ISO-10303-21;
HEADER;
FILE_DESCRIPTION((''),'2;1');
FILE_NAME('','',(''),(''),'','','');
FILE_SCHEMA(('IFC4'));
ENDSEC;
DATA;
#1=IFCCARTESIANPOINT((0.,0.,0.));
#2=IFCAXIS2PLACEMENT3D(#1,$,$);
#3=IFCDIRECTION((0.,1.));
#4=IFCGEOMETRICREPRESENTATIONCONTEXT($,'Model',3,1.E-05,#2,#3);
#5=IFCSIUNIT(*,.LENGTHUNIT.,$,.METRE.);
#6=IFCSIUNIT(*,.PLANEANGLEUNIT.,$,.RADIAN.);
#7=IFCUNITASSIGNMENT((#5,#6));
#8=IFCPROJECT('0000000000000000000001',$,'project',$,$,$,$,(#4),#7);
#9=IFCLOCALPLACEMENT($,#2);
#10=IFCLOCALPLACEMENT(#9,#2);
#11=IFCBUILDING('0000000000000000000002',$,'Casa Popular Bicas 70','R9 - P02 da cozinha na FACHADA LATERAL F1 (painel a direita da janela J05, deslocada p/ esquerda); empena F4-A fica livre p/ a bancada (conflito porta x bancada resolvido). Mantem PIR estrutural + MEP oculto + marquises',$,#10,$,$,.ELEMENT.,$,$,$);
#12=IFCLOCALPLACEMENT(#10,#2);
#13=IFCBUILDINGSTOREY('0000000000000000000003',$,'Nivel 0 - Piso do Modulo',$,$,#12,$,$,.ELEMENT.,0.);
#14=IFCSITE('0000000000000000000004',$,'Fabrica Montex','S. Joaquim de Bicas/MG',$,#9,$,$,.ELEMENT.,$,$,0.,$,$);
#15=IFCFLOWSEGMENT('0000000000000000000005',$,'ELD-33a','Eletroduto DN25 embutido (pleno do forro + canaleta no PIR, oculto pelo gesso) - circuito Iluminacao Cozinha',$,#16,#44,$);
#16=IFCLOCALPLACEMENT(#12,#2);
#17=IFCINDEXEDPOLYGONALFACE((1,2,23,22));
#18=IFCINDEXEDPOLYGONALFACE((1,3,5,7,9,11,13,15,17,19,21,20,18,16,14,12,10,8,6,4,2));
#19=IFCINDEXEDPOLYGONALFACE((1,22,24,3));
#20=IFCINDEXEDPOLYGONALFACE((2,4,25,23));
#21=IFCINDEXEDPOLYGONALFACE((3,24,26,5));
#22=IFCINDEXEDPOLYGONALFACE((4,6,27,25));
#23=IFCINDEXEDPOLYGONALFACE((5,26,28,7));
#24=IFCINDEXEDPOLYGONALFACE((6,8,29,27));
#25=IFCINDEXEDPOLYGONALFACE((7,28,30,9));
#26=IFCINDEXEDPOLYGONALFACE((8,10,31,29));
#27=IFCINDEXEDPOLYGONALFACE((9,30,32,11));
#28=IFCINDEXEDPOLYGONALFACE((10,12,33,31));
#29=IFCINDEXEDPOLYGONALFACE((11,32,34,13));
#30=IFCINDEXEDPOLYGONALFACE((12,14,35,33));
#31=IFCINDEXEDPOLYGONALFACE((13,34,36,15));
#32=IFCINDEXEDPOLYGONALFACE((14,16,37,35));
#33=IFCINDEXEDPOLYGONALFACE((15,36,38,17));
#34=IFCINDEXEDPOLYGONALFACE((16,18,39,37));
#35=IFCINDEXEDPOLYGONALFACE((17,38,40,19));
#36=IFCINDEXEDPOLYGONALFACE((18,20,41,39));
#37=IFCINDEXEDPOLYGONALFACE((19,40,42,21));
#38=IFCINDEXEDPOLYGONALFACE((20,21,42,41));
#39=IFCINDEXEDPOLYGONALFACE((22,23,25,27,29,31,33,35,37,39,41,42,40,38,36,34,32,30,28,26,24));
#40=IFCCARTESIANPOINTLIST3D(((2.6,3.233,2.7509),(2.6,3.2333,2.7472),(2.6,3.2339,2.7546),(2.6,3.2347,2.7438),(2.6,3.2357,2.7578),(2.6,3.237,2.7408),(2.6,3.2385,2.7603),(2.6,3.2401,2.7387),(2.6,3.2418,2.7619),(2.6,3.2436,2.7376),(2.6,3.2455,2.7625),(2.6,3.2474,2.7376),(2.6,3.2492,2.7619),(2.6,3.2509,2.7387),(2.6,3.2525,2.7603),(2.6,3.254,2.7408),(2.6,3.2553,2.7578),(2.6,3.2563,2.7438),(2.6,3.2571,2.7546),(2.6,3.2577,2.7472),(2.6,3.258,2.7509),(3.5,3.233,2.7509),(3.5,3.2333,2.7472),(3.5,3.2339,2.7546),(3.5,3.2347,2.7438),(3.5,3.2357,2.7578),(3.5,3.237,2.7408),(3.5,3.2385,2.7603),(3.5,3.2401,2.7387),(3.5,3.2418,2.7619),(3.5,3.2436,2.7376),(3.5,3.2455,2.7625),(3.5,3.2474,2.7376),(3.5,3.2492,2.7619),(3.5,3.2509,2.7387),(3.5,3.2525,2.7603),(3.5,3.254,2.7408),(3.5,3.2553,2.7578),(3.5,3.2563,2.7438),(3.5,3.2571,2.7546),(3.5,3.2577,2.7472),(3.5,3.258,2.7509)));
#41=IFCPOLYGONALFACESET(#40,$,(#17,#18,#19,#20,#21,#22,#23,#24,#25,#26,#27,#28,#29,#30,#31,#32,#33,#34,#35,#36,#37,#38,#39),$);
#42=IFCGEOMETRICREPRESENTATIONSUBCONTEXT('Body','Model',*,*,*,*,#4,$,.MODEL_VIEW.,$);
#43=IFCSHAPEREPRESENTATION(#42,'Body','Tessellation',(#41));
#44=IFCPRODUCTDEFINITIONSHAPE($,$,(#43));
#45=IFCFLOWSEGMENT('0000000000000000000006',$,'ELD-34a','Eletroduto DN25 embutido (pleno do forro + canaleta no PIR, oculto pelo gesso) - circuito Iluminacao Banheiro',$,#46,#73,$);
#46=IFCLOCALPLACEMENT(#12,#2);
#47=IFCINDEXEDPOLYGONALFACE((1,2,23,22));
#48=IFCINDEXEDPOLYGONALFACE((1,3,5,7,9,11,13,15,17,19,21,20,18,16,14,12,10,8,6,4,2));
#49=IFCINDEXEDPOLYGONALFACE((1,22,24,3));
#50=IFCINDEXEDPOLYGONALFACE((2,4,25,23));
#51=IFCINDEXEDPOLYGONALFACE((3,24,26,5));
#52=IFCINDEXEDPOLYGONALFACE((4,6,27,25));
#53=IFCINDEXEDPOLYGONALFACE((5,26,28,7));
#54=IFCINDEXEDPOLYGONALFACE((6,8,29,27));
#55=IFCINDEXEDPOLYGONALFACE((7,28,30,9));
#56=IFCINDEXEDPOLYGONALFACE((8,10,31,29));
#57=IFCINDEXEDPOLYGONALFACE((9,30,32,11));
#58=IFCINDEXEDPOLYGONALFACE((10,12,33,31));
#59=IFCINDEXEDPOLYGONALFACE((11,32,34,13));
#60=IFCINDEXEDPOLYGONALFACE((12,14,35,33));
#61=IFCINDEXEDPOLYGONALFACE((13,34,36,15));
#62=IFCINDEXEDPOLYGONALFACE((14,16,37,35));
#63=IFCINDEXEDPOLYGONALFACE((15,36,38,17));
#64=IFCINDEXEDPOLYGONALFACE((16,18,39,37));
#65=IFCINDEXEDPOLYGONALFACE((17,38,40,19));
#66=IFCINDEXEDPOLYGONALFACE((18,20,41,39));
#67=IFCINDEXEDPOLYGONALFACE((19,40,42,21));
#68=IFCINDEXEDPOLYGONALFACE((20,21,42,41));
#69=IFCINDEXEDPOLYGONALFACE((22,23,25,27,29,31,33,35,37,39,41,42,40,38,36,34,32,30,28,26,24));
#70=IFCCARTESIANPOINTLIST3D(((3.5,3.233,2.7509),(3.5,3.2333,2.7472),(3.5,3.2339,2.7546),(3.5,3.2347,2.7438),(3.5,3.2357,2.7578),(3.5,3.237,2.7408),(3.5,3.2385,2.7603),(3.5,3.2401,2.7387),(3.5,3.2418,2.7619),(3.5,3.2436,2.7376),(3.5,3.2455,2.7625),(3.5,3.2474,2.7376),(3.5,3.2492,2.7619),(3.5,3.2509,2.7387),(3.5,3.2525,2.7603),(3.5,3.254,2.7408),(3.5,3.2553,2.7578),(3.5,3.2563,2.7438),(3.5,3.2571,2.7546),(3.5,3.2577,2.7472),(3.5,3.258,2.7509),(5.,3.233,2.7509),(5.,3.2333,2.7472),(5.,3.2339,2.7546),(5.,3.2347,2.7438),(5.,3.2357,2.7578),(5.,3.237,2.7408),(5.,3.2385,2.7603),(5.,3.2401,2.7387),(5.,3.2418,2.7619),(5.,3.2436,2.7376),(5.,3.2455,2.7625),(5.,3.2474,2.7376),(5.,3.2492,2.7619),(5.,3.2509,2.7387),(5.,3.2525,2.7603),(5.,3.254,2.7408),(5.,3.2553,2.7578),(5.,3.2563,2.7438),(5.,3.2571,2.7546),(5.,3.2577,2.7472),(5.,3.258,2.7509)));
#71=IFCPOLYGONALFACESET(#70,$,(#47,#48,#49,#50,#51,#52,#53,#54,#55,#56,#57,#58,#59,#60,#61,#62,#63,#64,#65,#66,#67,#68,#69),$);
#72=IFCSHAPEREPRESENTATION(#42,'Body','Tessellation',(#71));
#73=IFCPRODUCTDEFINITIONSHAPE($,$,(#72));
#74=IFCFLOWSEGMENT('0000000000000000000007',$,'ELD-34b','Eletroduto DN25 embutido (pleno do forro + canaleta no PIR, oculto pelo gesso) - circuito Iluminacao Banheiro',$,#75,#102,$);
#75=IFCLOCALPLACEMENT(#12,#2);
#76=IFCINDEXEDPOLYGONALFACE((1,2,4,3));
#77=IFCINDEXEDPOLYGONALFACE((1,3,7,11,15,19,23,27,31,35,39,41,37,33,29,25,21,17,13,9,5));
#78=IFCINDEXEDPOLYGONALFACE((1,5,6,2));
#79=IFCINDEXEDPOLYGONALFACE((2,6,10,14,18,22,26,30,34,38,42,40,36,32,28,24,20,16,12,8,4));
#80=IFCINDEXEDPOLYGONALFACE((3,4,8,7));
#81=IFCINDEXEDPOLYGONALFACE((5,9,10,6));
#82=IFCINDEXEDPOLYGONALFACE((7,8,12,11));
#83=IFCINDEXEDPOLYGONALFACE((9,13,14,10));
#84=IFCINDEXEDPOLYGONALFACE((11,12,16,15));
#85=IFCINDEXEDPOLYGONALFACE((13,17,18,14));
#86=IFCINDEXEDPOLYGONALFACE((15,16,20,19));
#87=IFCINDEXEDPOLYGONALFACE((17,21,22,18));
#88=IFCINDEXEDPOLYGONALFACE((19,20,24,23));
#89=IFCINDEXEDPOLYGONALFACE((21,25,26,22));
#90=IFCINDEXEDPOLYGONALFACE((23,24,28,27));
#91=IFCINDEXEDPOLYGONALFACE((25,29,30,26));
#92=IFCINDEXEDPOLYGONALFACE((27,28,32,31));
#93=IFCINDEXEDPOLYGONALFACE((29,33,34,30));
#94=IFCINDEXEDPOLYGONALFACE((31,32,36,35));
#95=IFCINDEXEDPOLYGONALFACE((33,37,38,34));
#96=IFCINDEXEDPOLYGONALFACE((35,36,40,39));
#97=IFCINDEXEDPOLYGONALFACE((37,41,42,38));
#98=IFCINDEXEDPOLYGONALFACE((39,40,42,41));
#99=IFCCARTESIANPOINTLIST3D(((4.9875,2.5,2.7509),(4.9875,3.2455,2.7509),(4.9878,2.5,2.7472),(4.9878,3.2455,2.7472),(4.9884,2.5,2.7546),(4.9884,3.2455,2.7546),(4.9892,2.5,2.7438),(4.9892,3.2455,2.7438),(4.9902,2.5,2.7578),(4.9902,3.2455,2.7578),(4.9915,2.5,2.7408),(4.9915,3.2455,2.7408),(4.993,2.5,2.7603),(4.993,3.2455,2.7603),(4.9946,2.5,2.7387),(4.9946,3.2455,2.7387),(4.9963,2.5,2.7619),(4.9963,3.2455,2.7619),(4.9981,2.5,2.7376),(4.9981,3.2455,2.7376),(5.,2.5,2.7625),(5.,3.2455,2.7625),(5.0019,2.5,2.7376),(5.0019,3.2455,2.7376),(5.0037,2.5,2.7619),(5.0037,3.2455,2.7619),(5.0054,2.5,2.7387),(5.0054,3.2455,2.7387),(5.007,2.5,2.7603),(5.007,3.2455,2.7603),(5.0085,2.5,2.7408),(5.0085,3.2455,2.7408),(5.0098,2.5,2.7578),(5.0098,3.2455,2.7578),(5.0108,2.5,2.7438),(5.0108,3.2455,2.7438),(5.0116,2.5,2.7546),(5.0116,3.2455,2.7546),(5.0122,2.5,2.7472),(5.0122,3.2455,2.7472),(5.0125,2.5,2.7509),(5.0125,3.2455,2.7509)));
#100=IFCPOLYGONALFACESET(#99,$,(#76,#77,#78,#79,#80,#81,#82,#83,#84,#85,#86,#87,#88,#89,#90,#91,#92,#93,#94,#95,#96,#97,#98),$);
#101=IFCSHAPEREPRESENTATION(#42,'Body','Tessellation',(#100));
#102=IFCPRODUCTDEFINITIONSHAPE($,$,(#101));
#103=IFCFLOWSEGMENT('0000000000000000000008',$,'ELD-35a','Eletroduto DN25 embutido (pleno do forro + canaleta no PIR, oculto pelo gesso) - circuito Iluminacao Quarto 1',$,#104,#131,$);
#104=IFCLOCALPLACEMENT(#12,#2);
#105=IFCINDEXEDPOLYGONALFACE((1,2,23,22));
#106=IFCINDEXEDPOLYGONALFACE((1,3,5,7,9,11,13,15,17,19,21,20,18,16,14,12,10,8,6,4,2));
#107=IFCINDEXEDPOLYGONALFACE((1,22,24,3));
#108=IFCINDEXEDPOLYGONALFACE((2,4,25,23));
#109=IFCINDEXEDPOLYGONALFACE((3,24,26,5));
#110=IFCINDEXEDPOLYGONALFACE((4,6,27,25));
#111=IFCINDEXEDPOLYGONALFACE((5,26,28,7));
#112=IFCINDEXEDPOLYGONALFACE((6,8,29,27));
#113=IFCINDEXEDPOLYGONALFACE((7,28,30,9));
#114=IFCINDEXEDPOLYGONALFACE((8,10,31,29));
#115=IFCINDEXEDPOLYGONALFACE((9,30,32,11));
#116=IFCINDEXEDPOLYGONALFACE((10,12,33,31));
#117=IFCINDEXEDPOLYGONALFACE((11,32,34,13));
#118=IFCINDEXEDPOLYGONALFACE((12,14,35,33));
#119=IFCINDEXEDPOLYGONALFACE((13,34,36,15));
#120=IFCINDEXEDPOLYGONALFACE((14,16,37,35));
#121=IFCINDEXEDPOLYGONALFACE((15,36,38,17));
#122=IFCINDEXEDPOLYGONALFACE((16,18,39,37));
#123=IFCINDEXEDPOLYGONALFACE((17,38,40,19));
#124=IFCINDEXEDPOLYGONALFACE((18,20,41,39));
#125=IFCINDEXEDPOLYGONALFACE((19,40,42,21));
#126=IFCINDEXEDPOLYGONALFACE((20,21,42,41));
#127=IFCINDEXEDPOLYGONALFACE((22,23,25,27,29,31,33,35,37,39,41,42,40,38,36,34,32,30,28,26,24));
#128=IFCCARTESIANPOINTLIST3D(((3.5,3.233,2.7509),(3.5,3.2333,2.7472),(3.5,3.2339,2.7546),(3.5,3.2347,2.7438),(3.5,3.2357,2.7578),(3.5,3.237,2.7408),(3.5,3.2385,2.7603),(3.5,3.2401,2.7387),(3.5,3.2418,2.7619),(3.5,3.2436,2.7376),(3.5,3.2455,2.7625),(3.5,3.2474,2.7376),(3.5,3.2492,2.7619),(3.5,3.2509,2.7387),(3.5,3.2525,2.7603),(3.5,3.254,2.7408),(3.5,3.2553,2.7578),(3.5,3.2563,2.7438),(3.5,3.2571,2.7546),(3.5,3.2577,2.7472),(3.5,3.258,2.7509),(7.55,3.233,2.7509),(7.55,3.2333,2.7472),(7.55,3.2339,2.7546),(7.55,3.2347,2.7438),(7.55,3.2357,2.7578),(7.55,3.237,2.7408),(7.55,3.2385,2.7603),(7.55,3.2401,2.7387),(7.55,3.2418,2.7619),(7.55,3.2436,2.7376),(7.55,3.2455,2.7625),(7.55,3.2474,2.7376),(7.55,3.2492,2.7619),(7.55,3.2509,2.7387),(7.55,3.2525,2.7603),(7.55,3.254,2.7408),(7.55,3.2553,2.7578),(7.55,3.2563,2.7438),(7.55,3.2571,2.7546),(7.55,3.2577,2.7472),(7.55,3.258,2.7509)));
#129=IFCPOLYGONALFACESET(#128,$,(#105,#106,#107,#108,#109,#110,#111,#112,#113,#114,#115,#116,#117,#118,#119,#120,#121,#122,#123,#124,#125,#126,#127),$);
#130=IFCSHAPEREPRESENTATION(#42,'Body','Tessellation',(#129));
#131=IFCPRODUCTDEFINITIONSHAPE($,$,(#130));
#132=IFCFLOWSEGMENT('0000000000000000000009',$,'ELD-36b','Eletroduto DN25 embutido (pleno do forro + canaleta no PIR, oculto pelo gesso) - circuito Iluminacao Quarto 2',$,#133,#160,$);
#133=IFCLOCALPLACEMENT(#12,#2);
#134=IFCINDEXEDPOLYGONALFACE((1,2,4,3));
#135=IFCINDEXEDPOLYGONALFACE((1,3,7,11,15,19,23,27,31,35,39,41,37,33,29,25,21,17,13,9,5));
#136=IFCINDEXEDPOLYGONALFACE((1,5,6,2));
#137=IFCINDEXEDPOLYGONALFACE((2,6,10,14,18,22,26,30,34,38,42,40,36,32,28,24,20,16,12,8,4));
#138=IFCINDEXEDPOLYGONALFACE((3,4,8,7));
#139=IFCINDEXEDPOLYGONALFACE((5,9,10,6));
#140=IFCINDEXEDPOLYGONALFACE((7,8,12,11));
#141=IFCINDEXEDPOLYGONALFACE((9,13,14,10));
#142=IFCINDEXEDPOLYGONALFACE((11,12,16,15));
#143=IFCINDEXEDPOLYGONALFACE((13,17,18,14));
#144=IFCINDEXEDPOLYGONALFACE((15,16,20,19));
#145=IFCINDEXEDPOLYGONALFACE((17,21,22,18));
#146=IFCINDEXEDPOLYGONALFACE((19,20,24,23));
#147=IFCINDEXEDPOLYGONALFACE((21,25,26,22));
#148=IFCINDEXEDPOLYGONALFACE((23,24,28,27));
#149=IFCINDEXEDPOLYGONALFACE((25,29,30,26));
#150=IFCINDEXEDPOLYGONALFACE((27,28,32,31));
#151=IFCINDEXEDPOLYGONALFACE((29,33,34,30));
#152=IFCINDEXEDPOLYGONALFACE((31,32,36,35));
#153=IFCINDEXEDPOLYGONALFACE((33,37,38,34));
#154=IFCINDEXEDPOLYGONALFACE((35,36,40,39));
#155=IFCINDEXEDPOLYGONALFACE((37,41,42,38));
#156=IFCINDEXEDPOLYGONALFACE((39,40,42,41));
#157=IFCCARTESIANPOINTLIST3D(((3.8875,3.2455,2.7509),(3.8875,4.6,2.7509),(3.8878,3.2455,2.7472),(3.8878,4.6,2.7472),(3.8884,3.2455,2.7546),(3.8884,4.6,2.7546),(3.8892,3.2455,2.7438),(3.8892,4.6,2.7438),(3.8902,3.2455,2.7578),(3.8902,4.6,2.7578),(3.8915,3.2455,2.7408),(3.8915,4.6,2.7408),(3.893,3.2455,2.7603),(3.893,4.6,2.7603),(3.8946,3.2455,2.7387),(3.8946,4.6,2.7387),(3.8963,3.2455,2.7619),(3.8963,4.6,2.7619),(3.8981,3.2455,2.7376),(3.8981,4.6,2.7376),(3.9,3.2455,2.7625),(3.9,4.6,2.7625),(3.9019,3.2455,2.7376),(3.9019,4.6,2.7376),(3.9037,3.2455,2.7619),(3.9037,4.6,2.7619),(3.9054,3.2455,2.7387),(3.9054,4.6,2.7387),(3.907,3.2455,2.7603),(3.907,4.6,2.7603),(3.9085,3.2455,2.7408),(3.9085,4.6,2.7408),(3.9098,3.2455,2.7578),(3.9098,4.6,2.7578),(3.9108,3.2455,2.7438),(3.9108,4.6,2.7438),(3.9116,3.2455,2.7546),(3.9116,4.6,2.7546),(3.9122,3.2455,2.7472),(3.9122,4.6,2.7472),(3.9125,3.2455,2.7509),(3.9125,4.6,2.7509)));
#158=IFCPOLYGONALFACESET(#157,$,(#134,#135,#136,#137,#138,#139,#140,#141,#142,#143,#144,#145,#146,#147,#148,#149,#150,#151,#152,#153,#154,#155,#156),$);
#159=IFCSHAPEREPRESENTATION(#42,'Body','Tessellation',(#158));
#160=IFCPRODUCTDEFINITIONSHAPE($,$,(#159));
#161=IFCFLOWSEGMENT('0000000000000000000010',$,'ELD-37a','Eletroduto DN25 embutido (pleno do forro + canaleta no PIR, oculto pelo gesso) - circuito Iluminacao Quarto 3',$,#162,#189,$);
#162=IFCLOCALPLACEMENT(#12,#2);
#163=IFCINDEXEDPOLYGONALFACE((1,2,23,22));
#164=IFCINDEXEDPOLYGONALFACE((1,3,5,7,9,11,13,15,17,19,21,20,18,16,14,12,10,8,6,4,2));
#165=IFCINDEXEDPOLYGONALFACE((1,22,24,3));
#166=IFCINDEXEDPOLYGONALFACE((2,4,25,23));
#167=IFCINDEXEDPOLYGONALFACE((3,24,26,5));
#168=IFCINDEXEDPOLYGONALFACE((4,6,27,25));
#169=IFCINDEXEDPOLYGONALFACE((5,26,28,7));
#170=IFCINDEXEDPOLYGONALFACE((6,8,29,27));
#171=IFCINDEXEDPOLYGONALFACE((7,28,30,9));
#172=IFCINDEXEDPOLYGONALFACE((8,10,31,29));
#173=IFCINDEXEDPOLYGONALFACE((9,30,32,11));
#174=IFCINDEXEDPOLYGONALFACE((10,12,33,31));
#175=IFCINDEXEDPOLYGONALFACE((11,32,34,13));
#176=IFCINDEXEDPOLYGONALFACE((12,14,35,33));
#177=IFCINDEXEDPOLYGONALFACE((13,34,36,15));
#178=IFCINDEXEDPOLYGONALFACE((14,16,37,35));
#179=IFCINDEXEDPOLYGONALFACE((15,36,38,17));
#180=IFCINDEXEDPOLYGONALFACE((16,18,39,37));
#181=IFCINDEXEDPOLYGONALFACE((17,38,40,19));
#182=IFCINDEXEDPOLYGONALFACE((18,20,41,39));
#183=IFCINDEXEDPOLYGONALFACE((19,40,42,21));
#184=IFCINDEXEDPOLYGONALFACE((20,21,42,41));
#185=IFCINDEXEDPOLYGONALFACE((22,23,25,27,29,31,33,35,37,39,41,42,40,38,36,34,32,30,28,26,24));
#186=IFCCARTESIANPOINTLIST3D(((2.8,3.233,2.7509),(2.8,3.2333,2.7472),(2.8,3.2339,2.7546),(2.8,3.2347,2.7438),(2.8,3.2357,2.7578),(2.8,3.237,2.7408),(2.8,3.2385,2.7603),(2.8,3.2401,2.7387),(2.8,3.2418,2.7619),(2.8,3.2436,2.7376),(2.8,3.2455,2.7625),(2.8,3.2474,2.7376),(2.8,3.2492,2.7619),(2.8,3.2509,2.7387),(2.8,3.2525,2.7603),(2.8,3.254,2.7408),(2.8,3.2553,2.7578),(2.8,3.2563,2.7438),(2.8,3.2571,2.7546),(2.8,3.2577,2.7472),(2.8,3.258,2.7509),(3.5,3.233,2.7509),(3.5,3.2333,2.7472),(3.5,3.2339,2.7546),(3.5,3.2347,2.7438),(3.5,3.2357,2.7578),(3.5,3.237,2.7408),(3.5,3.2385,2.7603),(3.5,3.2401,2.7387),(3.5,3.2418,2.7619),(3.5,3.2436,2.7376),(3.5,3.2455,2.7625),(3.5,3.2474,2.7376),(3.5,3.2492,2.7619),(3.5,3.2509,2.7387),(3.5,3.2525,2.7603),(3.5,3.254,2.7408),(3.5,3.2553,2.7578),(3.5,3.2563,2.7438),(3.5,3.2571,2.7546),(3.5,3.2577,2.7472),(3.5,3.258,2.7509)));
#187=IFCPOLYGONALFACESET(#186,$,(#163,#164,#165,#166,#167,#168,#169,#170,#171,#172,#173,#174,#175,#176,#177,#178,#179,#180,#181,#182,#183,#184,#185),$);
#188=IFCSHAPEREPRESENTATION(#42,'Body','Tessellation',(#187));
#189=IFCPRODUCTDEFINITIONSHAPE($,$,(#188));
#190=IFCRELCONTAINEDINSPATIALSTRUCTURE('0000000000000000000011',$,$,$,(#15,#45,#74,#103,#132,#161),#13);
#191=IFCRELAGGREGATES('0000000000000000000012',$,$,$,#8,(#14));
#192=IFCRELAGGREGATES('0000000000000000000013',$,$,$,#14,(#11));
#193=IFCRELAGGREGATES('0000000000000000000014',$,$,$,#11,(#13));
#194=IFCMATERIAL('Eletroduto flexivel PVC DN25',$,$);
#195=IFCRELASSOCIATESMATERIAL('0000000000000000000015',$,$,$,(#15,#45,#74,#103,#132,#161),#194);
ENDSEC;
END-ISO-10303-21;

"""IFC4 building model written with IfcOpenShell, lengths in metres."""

from ifc_helpers import new_model, si_unit, direction, frame, origin, origin_2d, place, context, subcontext, project, spatial, circle, extrude, material, element, save


model = new_model("IFC4")

# Units and contexts
model_context_1 = context("Model", 3, precision=1e-05, world=origin(), true_north=direction((0.0, 1.0)))
body_context_1 = subcontext(model_context_1, "Body", "Model", "MODEL_VIEW")
ifc_project = project(units=[si_unit("LENGTHUNIT", "METRE"), si_unit("PLANEANGLEUNIT", "RADIAN")], contexts=[model_context_1])

# Site, building, storey
site_placement = place(None, origin())
site = spatial("IfcSite", under=ifc_project, at=site_placement, Name="Fabrica Montex", Description="S. Joaquim de Bicas/MG", CompositionType="ELEMENT", RefElevation=0.0)
building_placement = place(site_placement, origin())
building = spatial("IfcBuilding", under=site, at=building_placement, Name="Casa Popular Bicas 70", Description="R9 - P02 da cozinha na FACHADA LATERAL F1 (painel a direita da janela J05, deslocada p/ esquerda); empena F4-A fica livre p/ a bancada (conflito porta x bancada resolvido). Mantem PIR estrutural + MEP oculto + marquises", CompositionType="ELEMENT")
storey_placement = place(building_placement, origin())
storey = spatial("IfcBuildingStorey", under=building, at=storey_placement, Name="Nivel 0 - Piso do Modulo", CompositionType="ELEMENT", Elevation=0.0)

# Flow segments
ifc_material_1 = material(Name="Eletroduto flexivel PVC DN25")
flow_segment_1_placement = place(storey_placement, frame((3.5, 3.2455, 2.75), z_axis=(-1.0, 0.0, 0.0), x_axis=(0.0, 0.0, 1.0)))
element("IfcFlowSegment", 1, at=flow_segment_1_placement, inside=storey, material=ifc_material_1, Name="ELD-33a", Description="Eletroduto DN25 embutido (pleno do forro + canaleta no PIR, oculto pelo gesso) - circuito Iluminacao Cozinha", context=body_context_1, shape_type="SweptSolid", body=[
    extrude(circle(Radius=0.0125, at=origin_2d()), origin(), (0.0, 0.0, 1.0), 0.9),
])
flow_segment_2_placement = place(storey_placement, frame((3.5, 3.2455, 2.75), z_axis=(1.0, 0.0, 0.0), x_axis=(0.0, 0.0, 1.0)))
element("IfcFlowSegment", 2, at=flow_segment_2_placement, inside=storey, material=ifc_material_1, Name="ELD-34a", Description="Eletroduto DN25 embutido (pleno do forro + canaleta no PIR, oculto pelo gesso) - circuito Iluminacao Banheiro", context=body_context_1, shape_type="SweptSolid", body=[
    extrude(circle(Radius=0.0125, at=origin_2d()), origin(), (0.0, 0.0, 1.0), 1.5),
])
flow_segment_3_placement = place(storey_placement, frame((5.0, 3.2455, 2.75), z_axis=(0.0, -1.0, 0.0), x_axis=(0.0, 0.0, 1.0)))
element("IfcFlowSegment", 3, at=flow_segment_3_placement, inside=storey, material=ifc_material_1, Name="ELD-34b", Description="Eletroduto DN25 embutido (pleno do forro + canaleta no PIR, oculto pelo gesso) - circuito Iluminacao Banheiro", context=body_context_1, shape_type="SweptSolid", body=[
    extrude(circle(Radius=0.0125, at=origin_2d()), origin(), (0.0, 0.0, 1.0), 0.7455),
])
flow_segment_4_placement = place(storey_placement, frame((3.5, 3.2455, 2.75), z_axis=(1.0, 0.0, 0.0), x_axis=(0.0, 0.0, 1.0)))
element("IfcFlowSegment", 4, at=flow_segment_4_placement, inside=storey, material=ifc_material_1, Name="ELD-35a", Description="Eletroduto DN25 embutido (pleno do forro + canaleta no PIR, oculto pelo gesso) - circuito Iluminacao Quarto 1", context=body_context_1, shape_type="SweptSolid", body=[
    extrude(circle(Radius=0.0125, at=origin_2d()), origin(), (0.0, 0.0, 1.0), 4.05),
])
flow_segment_5_placement = place(storey_placement, frame((3.9, 3.2455, 2.75), z_axis=(0.0, 1.0, 0.0), x_axis=(0.0, 0.0, 1.0)))
element("IfcFlowSegment", 5, at=flow_segment_5_placement, inside=storey, material=ifc_material_1, Name="ELD-36b", Description="Eletroduto DN25 embutido (pleno do forro + canaleta no PIR, oculto pelo gesso) - circuito Iluminacao Quarto 2", context=body_context_1, shape_type="SweptSolid", body=[
    extrude(circle(Radius=0.0125, at=origin_2d()), origin(), (0.0, 0.0, 1.0), 1.3545),
])
flow_segment_6_placement = place(storey_placement, frame((3.5, 3.2455, 2.75), z_axis=(-1.0, 0.0, 0.0), x_axis=(0.0, 0.0, 1.0)))
element("IfcFlowSegment", 6, at=flow_segment_6_placement, inside=storey, material=ifc_material_1, Name="ELD-37a", Description="Eletroduto DN25 embutido (pleno do forro + canaleta no PIR, oculto pelo gesso) - circuito Iluminacao Quarto 3", context=body_context_1, shape_type="SweptSolid", body=[
    extrude(circle(Radius=0.0125, at=origin_2d()), origin(), (0.0, 0.0, 1.0), 0.7),
])

save(model, "model.ifc")
